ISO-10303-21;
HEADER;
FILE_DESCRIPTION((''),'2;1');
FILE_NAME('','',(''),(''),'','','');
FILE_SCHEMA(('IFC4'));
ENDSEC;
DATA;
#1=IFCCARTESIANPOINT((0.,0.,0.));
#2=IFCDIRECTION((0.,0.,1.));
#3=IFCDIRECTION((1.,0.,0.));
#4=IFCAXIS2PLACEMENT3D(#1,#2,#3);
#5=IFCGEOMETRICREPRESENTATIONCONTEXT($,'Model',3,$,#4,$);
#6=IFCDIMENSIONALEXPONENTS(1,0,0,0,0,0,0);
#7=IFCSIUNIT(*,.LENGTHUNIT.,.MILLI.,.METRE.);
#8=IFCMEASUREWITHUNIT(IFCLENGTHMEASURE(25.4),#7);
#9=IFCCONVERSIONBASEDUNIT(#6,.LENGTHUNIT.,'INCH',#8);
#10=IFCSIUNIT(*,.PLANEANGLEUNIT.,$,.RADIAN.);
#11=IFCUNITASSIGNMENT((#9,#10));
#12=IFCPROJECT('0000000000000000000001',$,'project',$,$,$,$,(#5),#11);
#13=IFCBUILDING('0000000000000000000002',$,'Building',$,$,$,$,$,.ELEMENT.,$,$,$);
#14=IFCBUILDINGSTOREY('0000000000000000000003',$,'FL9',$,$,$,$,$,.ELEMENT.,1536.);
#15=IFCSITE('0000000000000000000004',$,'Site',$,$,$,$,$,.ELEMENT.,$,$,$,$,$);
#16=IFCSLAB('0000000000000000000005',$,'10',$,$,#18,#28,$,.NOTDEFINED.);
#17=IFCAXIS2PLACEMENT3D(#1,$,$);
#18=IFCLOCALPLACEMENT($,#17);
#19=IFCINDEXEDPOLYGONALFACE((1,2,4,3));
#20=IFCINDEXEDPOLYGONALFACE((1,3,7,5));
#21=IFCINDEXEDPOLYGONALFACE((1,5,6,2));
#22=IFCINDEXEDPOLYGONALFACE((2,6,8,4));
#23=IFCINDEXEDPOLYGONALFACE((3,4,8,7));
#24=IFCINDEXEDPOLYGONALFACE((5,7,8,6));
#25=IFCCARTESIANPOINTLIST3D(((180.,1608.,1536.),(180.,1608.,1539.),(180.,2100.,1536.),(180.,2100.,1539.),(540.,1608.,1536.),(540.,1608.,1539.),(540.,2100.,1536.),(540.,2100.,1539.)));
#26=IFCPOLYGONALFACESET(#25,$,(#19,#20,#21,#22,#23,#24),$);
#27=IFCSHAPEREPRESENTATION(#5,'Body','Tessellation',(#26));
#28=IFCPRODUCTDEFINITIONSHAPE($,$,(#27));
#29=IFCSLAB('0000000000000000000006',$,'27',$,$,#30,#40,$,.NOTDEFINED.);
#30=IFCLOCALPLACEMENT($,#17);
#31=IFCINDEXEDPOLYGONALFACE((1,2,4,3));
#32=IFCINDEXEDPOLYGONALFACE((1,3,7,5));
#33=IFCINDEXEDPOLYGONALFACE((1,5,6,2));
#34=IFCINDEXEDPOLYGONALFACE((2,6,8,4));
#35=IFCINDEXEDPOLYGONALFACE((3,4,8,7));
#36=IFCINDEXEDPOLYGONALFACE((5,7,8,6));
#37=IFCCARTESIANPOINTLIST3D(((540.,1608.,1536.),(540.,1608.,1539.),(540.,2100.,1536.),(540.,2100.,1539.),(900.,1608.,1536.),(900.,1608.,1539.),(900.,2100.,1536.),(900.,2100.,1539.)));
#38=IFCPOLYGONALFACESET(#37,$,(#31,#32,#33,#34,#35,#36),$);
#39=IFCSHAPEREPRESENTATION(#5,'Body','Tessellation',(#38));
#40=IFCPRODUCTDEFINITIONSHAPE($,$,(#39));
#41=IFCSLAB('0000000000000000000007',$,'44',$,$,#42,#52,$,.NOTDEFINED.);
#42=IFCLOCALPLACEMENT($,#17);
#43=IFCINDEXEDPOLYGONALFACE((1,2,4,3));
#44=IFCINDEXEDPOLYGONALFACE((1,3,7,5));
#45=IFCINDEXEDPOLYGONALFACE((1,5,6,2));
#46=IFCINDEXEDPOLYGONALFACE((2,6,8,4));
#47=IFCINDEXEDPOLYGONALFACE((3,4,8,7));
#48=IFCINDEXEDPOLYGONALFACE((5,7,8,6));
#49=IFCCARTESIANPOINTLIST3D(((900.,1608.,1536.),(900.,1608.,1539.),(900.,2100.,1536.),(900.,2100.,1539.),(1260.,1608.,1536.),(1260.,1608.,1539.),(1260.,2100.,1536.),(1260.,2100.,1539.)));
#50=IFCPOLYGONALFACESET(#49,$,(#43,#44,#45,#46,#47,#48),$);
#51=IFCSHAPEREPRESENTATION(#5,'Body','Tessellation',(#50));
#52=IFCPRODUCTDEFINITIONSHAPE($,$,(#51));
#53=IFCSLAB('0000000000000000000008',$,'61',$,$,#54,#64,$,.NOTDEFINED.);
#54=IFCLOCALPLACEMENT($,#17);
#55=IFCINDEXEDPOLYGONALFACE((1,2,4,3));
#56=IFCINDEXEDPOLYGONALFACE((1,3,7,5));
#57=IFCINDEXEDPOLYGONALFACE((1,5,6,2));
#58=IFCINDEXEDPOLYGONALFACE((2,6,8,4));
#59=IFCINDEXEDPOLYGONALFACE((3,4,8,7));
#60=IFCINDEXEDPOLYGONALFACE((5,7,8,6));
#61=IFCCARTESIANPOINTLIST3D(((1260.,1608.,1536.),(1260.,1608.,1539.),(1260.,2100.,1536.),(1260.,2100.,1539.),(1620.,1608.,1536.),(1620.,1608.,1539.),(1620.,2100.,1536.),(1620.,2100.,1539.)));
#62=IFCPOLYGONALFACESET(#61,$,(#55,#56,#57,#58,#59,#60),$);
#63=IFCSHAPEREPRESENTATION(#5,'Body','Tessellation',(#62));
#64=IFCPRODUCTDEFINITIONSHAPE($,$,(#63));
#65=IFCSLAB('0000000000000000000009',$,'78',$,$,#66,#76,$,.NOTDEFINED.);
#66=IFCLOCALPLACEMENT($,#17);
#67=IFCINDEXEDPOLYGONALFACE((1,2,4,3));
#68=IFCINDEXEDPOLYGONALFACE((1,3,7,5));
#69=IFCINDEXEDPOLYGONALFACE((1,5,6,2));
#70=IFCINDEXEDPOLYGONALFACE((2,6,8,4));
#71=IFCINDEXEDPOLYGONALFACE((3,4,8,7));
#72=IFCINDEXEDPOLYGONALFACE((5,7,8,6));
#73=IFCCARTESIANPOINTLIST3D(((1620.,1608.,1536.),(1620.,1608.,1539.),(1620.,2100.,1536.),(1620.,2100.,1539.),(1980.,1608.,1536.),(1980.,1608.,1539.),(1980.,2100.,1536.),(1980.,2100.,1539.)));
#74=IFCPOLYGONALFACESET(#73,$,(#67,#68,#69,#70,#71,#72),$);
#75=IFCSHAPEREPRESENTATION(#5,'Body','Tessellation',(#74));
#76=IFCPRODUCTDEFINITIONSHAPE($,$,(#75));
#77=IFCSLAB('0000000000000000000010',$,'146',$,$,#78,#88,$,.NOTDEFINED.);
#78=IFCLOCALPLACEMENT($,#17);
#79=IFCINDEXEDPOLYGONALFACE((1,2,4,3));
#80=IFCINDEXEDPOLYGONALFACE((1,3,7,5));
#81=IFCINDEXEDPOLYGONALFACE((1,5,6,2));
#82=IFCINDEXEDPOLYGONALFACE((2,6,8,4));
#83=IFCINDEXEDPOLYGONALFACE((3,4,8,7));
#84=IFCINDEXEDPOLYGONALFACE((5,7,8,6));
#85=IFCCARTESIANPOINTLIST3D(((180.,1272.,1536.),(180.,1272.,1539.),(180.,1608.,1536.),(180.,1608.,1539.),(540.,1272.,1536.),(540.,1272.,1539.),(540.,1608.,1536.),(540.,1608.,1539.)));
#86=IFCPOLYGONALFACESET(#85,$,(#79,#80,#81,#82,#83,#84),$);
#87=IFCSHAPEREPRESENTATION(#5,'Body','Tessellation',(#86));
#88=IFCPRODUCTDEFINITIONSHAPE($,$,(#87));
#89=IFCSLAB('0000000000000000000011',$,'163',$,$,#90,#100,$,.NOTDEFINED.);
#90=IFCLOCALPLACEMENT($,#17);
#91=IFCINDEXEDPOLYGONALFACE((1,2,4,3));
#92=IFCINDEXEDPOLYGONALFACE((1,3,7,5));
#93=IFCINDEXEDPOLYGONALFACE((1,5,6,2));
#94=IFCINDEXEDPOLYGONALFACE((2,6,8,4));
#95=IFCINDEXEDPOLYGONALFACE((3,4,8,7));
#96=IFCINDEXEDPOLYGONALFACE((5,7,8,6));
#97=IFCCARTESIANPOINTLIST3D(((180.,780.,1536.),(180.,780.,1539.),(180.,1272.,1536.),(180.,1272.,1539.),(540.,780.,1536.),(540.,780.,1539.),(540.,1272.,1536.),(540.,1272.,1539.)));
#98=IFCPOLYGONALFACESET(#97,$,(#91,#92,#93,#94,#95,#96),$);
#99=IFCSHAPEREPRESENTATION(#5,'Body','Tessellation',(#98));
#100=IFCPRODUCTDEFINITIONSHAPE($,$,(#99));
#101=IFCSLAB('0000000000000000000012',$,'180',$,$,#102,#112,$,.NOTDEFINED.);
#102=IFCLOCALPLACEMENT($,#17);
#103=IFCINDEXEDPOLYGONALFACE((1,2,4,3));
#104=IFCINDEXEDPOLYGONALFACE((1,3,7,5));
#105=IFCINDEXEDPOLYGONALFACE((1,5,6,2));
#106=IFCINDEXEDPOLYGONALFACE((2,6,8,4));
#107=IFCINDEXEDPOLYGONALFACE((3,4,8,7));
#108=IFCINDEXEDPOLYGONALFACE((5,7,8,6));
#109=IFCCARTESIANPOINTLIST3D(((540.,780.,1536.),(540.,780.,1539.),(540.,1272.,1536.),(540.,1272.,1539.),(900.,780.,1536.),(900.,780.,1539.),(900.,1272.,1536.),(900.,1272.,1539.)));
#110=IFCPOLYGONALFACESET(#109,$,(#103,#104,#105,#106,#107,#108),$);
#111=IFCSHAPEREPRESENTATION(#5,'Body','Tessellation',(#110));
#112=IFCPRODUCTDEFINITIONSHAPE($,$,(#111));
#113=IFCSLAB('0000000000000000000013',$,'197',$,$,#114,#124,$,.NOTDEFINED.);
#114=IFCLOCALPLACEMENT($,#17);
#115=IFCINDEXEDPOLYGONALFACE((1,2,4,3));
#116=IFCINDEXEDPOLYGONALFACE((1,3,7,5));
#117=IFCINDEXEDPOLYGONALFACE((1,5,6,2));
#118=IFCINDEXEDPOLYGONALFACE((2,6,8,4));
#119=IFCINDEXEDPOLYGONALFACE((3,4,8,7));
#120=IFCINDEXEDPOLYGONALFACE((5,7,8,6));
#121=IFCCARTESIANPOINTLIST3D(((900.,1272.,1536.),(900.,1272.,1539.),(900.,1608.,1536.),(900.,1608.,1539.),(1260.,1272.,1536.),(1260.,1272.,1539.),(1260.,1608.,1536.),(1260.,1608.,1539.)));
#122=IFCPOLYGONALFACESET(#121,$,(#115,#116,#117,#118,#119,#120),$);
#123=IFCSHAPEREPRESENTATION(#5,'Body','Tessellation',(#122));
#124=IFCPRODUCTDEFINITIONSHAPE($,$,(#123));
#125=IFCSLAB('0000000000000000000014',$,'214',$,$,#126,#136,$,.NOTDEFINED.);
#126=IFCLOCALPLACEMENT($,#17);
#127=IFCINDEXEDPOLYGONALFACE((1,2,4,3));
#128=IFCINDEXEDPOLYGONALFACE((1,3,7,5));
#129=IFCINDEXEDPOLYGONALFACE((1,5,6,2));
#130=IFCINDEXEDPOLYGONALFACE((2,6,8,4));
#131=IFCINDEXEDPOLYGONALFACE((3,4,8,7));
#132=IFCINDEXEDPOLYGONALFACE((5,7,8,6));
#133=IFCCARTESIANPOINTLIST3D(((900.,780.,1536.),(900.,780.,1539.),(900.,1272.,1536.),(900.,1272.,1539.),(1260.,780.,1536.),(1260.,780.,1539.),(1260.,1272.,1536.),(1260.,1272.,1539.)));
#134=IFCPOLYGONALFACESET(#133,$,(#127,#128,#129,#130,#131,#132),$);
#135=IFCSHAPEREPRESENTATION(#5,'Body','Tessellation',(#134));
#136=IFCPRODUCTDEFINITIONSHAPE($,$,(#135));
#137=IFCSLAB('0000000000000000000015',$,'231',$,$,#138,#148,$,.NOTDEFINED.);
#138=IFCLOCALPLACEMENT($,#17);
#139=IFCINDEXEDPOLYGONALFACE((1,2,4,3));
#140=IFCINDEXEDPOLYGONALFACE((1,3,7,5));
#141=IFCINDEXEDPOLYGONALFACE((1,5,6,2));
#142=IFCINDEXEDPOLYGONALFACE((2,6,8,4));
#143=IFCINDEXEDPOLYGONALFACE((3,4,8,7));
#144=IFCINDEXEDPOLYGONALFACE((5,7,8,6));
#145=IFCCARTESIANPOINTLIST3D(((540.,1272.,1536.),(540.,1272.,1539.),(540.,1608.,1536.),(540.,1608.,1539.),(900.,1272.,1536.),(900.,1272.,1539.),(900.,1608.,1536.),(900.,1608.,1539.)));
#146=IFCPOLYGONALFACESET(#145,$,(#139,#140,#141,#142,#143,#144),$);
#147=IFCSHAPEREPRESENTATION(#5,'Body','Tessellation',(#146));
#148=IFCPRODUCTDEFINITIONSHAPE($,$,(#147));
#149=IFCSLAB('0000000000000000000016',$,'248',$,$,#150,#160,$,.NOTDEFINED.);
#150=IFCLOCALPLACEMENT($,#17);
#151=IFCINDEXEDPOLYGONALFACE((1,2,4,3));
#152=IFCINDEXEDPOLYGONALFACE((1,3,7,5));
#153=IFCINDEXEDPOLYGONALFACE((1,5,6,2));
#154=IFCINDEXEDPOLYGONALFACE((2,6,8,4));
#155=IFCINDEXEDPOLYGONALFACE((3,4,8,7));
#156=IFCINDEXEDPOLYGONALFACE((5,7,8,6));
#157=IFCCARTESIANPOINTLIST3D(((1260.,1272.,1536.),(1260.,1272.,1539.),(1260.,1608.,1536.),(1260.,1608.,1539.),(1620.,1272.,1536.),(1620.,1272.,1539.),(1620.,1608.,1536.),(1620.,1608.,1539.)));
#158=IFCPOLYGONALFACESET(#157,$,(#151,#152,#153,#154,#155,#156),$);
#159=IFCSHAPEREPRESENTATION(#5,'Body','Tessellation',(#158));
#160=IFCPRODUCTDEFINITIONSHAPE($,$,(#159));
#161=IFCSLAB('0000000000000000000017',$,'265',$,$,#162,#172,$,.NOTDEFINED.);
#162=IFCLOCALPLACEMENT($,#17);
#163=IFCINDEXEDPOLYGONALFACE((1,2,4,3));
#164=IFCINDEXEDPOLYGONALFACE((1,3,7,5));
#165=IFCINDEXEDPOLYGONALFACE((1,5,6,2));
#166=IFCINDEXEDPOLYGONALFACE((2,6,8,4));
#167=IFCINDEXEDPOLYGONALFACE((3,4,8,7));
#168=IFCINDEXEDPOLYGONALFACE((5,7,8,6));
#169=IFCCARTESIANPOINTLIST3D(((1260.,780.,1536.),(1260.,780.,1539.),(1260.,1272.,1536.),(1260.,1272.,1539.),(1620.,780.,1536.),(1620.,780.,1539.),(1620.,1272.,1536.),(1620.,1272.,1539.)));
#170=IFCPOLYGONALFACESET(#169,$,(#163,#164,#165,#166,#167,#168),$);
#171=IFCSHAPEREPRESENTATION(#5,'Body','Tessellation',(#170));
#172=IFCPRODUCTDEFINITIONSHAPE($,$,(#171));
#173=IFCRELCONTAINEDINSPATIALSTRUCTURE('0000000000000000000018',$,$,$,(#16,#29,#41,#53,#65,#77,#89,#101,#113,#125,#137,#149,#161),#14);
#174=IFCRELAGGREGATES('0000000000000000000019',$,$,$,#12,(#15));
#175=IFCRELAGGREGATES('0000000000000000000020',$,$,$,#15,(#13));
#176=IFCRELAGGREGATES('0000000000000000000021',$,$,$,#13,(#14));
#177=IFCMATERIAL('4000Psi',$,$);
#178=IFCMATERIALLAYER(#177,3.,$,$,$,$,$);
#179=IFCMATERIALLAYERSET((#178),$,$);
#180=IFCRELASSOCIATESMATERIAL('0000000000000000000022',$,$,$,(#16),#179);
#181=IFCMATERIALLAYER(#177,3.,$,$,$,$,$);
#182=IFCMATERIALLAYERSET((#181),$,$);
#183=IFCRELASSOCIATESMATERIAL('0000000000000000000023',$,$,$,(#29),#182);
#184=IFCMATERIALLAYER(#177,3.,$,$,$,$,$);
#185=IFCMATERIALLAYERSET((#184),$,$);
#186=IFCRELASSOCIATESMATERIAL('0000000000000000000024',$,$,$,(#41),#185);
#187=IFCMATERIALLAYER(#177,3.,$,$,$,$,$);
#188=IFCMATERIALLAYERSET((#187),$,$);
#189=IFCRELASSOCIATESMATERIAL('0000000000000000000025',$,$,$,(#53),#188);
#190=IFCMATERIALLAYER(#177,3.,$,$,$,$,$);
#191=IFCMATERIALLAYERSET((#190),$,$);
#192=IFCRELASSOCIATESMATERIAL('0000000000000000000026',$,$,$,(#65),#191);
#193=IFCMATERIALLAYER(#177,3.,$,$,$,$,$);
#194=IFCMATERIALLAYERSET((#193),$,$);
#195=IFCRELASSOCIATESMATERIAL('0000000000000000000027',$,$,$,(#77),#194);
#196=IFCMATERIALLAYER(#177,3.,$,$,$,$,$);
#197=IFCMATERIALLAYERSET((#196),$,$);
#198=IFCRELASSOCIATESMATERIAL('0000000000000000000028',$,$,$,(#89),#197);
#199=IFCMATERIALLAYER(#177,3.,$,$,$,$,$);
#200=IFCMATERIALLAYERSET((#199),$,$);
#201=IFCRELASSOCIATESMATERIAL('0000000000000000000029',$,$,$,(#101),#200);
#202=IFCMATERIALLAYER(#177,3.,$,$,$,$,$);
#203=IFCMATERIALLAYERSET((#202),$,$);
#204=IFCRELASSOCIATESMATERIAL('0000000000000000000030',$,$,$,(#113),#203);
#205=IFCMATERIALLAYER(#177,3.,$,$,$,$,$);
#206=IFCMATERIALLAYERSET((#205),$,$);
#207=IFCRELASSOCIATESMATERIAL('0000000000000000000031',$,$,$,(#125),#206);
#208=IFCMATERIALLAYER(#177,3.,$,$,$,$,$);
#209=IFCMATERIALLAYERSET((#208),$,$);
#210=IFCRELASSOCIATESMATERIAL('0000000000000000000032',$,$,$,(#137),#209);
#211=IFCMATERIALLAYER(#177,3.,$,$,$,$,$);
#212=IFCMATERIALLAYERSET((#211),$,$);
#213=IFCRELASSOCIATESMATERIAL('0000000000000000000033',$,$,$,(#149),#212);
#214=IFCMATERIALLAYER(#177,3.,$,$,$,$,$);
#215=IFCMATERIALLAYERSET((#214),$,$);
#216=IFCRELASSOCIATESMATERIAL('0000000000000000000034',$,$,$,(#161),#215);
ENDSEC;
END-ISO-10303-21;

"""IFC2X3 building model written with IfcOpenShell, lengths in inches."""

from ifc_helpers import new_model, entity, si_unit, converted_unit, frame, origin_with_axes, place, context, project, spatial, polyline, outline, extrude, material, layer, layer_set, layer_usage, element, save


model = new_model("IFC2X3")

# Units and contexts
model_context = context("Model", 3, world=origin_with_axes())
ifc_project = project(units=[converted_unit("LENGTHUNIT", "INCH", entity("IfcLengthMeasure", 25.4), si_unit("LENGTHUNIT", "METRE", prefix="MILLI"), dimensions=[1, 0, 0, 0, 0, 0, 0]), si_unit("PLANEANGLEUNIT", "RADIAN")], contexts=[model_context])

# Site, building, storey
site = spatial("IfcSite", under=ifc_project, Name="Site", CompositionType="ELEMENT")
building = spatial("IfcBuilding", under=site, Name="Building", CompositionType="ELEMENT")
storey = spatial("IfcBuildingStorey", under=building, Name="FL9", CompositionType="ELEMENT", Elevation=1536.0)

# Slabs
ifc_material_1 = material(Name="4000Psi")
ifc_layer_1 = layer(ifc_material_1, 3.0)
ifc_layer_set_1 = layer_set([ifc_layer_1])
ifc_layer_usage_1 = layer_usage(ifc_layer_set_1, "AXIS2", "POSITIVE", -3.0)
slab_1_placement = place(None, frame((180.0, 1608.0, 1536.0), z_axis=(0.0, 0.0, 1.0), x_axis=(1.0, 0.0, 0.0)))
element("IfcSlab", 1, at=slab_1_placement, inside=storey, material=ifc_layer_usage_1, Name="10", PredefinedType="NOTDEFINED", context=model_context, shape_type="SweptSolid", body=[
    extrude(outline(polyline([(0.0, 0.0), (360.0, 0.0), (360.0, 492.0), (0.0, 492.0), (0.0, 0.0)])), origin_with_axes(), (0.0, 0.0, 1.0), 3.0),
])
ifc_layer_2 = layer(ifc_material_1, 3.0)
ifc_layer_set_2 = layer_set([ifc_layer_2])
ifc_layer_usage_2 = layer_usage(ifc_layer_set_2, "AXIS2", "POSITIVE", -3.0)
slab_2_placement = place(None, frame((540.0, 1608.0, 1536.0), z_axis=(0.0, 0.0, 1.0), x_axis=(1.0, 0.0, 0.0)))
element("IfcSlab", 2, at=slab_2_placement, inside=storey, material=ifc_layer_usage_2, Name="27", PredefinedType="NOTDEFINED", context=model_context, shape_type="SweptSolid", body=[
    extrude(outline(polyline([(0.0, 0.0), (360.0, 0.0), (360.0, 492.0), (0.0, 492.0), (0.0, 0.0)])), origin_with_axes(), (0.0, 0.0, 1.0), 3.0),
])
ifc_layer_3 = layer(ifc_material_1, 3.0)
ifc_layer_set_3 = layer_set([ifc_layer_3])
ifc_layer_usage_3 = layer_usage(ifc_layer_set_3, "AXIS2", "POSITIVE", -3.0)
slab_3_placement = place(None, frame((900.0, 1608.0, 1536.0), z_axis=(0.0, 0.0, 1.0), x_axis=(1.0, 0.0, 0.0)))
element("IfcSlab", 3, at=slab_3_placement, inside=storey, material=ifc_layer_usage_3, Name="44", PredefinedType="NOTDEFINED", context=model_context, shape_type="SweptSolid", body=[
    extrude(outline(polyline([(0.0, 0.0), (360.0, 0.0), (360.0, 492.0), (0.0, 492.0), (0.0, 0.0)])), origin_with_axes(), (0.0, 0.0, 1.0), 3.0),
])
ifc_layer_4 = layer(ifc_material_1, 3.0)
ifc_layer_set_4 = layer_set([ifc_layer_4])
ifc_layer_usage_4 = layer_usage(ifc_layer_set_4, "AXIS2", "POSITIVE", -3.0)
slab_4_placement = place(None, frame((1260.0, 1608.0, 1536.0), z_axis=(0.0, 0.0, 1.0), x_axis=(1.0, 0.0, 0.0)))
element("IfcSlab", 4, at=slab_4_placement, inside=storey, material=ifc_layer_usage_4, Name="61", PredefinedType="NOTDEFINED", context=model_context, shape_type="SweptSolid", body=[
    extrude(outline(polyline([(0.0, 0.0), (360.0, 0.0), (360.0, 492.0), (0.0, 492.0), (0.0, 0.0)])), origin_with_axes(), (0.0, 0.0, 1.0), 3.0),
])
ifc_layer_5 = layer(ifc_material_1, 3.0)
ifc_layer_set_5 = layer_set([ifc_layer_5])
ifc_layer_usage_5 = layer_usage(ifc_layer_set_5, "AXIS2", "POSITIVE", -3.0)
slab_5_placement = place(None, frame((1620.0, 1608.0, 1536.0), z_axis=(0.0, 0.0, 1.0), x_axis=(1.0, 0.0, 0.0)))
element("IfcSlab", 5, at=slab_5_placement, inside=storey, material=ifc_layer_usage_5, Name="78", PredefinedType="NOTDEFINED", context=model_context, shape_type="SweptSolid", body=[
    extrude(outline(polyline([(0.0, 0.0), (360.0, 0.0), (360.0, 492.0), (0.0, 492.0), (0.0, 0.0)])), origin_with_axes(), (0.0, 0.0, 1.0), 3.0),
])
ifc_layer_6 = layer(ifc_material_1, 3.0)
ifc_layer_set_6 = layer_set([ifc_layer_6])
ifc_layer_usage_6 = layer_usage(ifc_layer_set_6, "AXIS2", "POSITIVE", -3.0)
slab_6_placement = place(None, frame((180.0, 1272.0, 1536.0), z_axis=(0.0, 0.0, 1.0), x_axis=(1.0, 0.0, 0.0)))
element("IfcSlab", 6, at=slab_6_placement, inside=storey, material=ifc_layer_usage_6, Name="146", PredefinedType="NOTDEFINED", context=model_context, shape_type="SweptSolid", body=[
    extrude(outline(polyline([(0.0, 0.0), (360.0, 0.0), (360.0, 336.0), (0.0, 336.0), (0.0, 0.0)])), origin_with_axes(), (0.0, 0.0, 1.0), 3.0),
])
ifc_layer_7 = layer(ifc_material_1, 3.0)
ifc_layer_set_7 = layer_set([ifc_layer_7])
ifc_layer_usage_7 = layer_usage(ifc_layer_set_7, "AXIS2", "POSITIVE", -3.0)
slab_7_placement = place(None, frame((180.0, 780.0, 1536.0), z_axis=(0.0, 0.0, 1.0), x_axis=(1.0, 0.0, 0.0)))
element("IfcSlab", 7, at=slab_7_placement, inside=storey, material=ifc_layer_usage_7, Name="163", PredefinedType="NOTDEFINED", context=model_context, shape_type="SweptSolid", body=[
    extrude(outline(polyline([(0.0, 0.0), (360.0, 0.0), (360.0, 492.0), (0.0, 492.0), (0.0, 0.0)])), origin_with_axes(), (0.0, 0.0, 1.0), 3.0),
])
ifc_layer_8 = layer(ifc_material_1, 3.0)
ifc_layer_set_8 = layer_set([ifc_layer_8])
ifc_layer_usage_8 = layer_usage(ifc_layer_set_8, "AXIS2", "POSITIVE", -3.0)
slab_8_placement = place(None, frame((540.0, 780.0, 1536.0), z_axis=(0.0, 0.0, 1.0), x_axis=(1.0, 0.0, 0.0)))
element("IfcSlab", 8, at=slab_8_placement, inside=storey, material=ifc_layer_usage_8, Name="180", PredefinedType="NOTDEFINED", context=model_context, shape_type="SweptSolid", body=[
    extrude(outline(polyline([(0.0, 0.0), (360.0, 0.0), (360.0, 492.0), (0.0, 492.0), (0.0, 0.0)])), origin_with_axes(), (0.0, 0.0, 1.0), 3.0),
])
ifc_layer_9 = layer(ifc_material_1, 3.0)
ifc_layer_set_9 = layer_set([ifc_layer_9])
ifc_layer_usage_9 = layer_usage(ifc_layer_set_9, "AXIS2", "POSITIVE", -3.0)
slab_9_placement = place(None, frame((900.0, 1272.0, 1536.0), z_axis=(0.0, 0.0, 1.0), x_axis=(1.0, 0.0, 0.0)))
element("IfcSlab", 9, at=slab_9_placement, inside=storey, material=ifc_layer_usage_9, Name="197", PredefinedType="NOTDEFINED", context=model_context, shape_type="SweptSolid", body=[
    extrude(outline(polyline([(0.0, 0.0), (360.0, 0.0), (360.0, 336.0), (0.0, 336.0), (0.0, 0.0)])), origin_with_axes(), (0.0, 0.0, 1.0), 3.0),
])
ifc_layer_10 = layer(ifc_material_1, 3.0)
ifc_layer_set_10 = layer_set([ifc_layer_10])
ifc_layer_usage_10 = layer_usage(ifc_layer_set_10, "AXIS2", "POSITIVE", -3.0)
slab_10_placement = place(None, frame((900.0, 780.0, 1536.0), z_axis=(0.0, 0.0, 1.0), x_axis=(1.0, 0.0, 0.0)))
element("IfcSlab", 10, at=slab_10_placement, inside=storey, material=ifc_layer_usage_10, Name="214", PredefinedType="NOTDEFINED", context=model_context, shape_type="SweptSolid", body=[
    extrude(outline(polyline([(0.0, 0.0), (360.0, 0.0), (360.0, 492.0), (0.0, 492.0), (0.0, 0.0)])), origin_with_axes(), (0.0, 0.0, 1.0), 3.0),
])
ifc_layer_11 = layer(ifc_material_1, 3.0)
ifc_layer_set_11 = layer_set([ifc_layer_11])
ifc_layer_usage_11 = layer_usage(ifc_layer_set_11, "AXIS2", "POSITIVE", -3.0)
slab_11_placement = place(None, frame((540.0, 1272.0, 1536.0), z_axis=(0.0, 0.0, 1.0), x_axis=(1.0, 0.0, 0.0)))
element("IfcSlab", 11, at=slab_11_placement, inside=storey, material=ifc_layer_usage_11, Name="231", PredefinedType="NOTDEFINED", context=model_context, shape_type="SweptSolid", body=[
    extrude(outline(polyline([(0.0, 0.0), (360.0, 0.0), (360.0, 336.0), (0.0, 336.0), (0.0, 0.0)])), origin_with_axes(), (0.0, 0.0, 1.0), 3.0),
])
ifc_layer_12 = layer(ifc_material_1, 3.0)
ifc_layer_set_12 = layer_set([ifc_layer_12])
ifc_layer_usage_12 = layer_usage(ifc_layer_set_12, "AXIS2", "POSITIVE", -3.0)
slab_12_placement = place(None, frame((1260.0, 1272.0, 1536.0), z_axis=(0.0, 0.0, 1.0), x_axis=(1.0, 0.0, 0.0)))
element("IfcSlab", 12, at=slab_12_placement, inside=storey, material=ifc_layer_usage_12, Name="248", PredefinedType="NOTDEFINED", context=model_context, shape_type="SweptSolid", body=[
    extrude(outline(polyline([(0.0, 0.0), (360.0, 0.0), (360.0, 336.0), (0.0, 336.0), (0.0, 0.0)])), origin_with_axes(), (0.0, 0.0, 1.0), 3.0),
])
ifc_layer_13 = layer(ifc_material_1, 3.0)
ifc_layer_set_13 = layer_set([ifc_layer_13])
ifc_layer_usage_13 = layer_usage(ifc_layer_set_13, "AXIS2", "POSITIVE", -3.0)
slab_13_placement = place(None, frame((1260.0, 780.0, 1536.0), z_axis=(0.0, 0.0, 1.0), x_axis=(1.0, 0.0, 0.0)))
element("IfcSlab", 13, at=slab_13_placement, inside=storey, material=ifc_layer_usage_13, Name="265", PredefinedType="NOTDEFINED", context=model_context, shape_type="SweptSolid", body=[
    extrude(outline(polyline([(0.0, 0.0), (360.0, 0.0), (360.0, 492.0), (0.0, 492.0), (0.0, 0.0)])), origin_with_axes(), (0.0, 0.0, 1.0), 3.0),
])

save(model, "model.ifc")
